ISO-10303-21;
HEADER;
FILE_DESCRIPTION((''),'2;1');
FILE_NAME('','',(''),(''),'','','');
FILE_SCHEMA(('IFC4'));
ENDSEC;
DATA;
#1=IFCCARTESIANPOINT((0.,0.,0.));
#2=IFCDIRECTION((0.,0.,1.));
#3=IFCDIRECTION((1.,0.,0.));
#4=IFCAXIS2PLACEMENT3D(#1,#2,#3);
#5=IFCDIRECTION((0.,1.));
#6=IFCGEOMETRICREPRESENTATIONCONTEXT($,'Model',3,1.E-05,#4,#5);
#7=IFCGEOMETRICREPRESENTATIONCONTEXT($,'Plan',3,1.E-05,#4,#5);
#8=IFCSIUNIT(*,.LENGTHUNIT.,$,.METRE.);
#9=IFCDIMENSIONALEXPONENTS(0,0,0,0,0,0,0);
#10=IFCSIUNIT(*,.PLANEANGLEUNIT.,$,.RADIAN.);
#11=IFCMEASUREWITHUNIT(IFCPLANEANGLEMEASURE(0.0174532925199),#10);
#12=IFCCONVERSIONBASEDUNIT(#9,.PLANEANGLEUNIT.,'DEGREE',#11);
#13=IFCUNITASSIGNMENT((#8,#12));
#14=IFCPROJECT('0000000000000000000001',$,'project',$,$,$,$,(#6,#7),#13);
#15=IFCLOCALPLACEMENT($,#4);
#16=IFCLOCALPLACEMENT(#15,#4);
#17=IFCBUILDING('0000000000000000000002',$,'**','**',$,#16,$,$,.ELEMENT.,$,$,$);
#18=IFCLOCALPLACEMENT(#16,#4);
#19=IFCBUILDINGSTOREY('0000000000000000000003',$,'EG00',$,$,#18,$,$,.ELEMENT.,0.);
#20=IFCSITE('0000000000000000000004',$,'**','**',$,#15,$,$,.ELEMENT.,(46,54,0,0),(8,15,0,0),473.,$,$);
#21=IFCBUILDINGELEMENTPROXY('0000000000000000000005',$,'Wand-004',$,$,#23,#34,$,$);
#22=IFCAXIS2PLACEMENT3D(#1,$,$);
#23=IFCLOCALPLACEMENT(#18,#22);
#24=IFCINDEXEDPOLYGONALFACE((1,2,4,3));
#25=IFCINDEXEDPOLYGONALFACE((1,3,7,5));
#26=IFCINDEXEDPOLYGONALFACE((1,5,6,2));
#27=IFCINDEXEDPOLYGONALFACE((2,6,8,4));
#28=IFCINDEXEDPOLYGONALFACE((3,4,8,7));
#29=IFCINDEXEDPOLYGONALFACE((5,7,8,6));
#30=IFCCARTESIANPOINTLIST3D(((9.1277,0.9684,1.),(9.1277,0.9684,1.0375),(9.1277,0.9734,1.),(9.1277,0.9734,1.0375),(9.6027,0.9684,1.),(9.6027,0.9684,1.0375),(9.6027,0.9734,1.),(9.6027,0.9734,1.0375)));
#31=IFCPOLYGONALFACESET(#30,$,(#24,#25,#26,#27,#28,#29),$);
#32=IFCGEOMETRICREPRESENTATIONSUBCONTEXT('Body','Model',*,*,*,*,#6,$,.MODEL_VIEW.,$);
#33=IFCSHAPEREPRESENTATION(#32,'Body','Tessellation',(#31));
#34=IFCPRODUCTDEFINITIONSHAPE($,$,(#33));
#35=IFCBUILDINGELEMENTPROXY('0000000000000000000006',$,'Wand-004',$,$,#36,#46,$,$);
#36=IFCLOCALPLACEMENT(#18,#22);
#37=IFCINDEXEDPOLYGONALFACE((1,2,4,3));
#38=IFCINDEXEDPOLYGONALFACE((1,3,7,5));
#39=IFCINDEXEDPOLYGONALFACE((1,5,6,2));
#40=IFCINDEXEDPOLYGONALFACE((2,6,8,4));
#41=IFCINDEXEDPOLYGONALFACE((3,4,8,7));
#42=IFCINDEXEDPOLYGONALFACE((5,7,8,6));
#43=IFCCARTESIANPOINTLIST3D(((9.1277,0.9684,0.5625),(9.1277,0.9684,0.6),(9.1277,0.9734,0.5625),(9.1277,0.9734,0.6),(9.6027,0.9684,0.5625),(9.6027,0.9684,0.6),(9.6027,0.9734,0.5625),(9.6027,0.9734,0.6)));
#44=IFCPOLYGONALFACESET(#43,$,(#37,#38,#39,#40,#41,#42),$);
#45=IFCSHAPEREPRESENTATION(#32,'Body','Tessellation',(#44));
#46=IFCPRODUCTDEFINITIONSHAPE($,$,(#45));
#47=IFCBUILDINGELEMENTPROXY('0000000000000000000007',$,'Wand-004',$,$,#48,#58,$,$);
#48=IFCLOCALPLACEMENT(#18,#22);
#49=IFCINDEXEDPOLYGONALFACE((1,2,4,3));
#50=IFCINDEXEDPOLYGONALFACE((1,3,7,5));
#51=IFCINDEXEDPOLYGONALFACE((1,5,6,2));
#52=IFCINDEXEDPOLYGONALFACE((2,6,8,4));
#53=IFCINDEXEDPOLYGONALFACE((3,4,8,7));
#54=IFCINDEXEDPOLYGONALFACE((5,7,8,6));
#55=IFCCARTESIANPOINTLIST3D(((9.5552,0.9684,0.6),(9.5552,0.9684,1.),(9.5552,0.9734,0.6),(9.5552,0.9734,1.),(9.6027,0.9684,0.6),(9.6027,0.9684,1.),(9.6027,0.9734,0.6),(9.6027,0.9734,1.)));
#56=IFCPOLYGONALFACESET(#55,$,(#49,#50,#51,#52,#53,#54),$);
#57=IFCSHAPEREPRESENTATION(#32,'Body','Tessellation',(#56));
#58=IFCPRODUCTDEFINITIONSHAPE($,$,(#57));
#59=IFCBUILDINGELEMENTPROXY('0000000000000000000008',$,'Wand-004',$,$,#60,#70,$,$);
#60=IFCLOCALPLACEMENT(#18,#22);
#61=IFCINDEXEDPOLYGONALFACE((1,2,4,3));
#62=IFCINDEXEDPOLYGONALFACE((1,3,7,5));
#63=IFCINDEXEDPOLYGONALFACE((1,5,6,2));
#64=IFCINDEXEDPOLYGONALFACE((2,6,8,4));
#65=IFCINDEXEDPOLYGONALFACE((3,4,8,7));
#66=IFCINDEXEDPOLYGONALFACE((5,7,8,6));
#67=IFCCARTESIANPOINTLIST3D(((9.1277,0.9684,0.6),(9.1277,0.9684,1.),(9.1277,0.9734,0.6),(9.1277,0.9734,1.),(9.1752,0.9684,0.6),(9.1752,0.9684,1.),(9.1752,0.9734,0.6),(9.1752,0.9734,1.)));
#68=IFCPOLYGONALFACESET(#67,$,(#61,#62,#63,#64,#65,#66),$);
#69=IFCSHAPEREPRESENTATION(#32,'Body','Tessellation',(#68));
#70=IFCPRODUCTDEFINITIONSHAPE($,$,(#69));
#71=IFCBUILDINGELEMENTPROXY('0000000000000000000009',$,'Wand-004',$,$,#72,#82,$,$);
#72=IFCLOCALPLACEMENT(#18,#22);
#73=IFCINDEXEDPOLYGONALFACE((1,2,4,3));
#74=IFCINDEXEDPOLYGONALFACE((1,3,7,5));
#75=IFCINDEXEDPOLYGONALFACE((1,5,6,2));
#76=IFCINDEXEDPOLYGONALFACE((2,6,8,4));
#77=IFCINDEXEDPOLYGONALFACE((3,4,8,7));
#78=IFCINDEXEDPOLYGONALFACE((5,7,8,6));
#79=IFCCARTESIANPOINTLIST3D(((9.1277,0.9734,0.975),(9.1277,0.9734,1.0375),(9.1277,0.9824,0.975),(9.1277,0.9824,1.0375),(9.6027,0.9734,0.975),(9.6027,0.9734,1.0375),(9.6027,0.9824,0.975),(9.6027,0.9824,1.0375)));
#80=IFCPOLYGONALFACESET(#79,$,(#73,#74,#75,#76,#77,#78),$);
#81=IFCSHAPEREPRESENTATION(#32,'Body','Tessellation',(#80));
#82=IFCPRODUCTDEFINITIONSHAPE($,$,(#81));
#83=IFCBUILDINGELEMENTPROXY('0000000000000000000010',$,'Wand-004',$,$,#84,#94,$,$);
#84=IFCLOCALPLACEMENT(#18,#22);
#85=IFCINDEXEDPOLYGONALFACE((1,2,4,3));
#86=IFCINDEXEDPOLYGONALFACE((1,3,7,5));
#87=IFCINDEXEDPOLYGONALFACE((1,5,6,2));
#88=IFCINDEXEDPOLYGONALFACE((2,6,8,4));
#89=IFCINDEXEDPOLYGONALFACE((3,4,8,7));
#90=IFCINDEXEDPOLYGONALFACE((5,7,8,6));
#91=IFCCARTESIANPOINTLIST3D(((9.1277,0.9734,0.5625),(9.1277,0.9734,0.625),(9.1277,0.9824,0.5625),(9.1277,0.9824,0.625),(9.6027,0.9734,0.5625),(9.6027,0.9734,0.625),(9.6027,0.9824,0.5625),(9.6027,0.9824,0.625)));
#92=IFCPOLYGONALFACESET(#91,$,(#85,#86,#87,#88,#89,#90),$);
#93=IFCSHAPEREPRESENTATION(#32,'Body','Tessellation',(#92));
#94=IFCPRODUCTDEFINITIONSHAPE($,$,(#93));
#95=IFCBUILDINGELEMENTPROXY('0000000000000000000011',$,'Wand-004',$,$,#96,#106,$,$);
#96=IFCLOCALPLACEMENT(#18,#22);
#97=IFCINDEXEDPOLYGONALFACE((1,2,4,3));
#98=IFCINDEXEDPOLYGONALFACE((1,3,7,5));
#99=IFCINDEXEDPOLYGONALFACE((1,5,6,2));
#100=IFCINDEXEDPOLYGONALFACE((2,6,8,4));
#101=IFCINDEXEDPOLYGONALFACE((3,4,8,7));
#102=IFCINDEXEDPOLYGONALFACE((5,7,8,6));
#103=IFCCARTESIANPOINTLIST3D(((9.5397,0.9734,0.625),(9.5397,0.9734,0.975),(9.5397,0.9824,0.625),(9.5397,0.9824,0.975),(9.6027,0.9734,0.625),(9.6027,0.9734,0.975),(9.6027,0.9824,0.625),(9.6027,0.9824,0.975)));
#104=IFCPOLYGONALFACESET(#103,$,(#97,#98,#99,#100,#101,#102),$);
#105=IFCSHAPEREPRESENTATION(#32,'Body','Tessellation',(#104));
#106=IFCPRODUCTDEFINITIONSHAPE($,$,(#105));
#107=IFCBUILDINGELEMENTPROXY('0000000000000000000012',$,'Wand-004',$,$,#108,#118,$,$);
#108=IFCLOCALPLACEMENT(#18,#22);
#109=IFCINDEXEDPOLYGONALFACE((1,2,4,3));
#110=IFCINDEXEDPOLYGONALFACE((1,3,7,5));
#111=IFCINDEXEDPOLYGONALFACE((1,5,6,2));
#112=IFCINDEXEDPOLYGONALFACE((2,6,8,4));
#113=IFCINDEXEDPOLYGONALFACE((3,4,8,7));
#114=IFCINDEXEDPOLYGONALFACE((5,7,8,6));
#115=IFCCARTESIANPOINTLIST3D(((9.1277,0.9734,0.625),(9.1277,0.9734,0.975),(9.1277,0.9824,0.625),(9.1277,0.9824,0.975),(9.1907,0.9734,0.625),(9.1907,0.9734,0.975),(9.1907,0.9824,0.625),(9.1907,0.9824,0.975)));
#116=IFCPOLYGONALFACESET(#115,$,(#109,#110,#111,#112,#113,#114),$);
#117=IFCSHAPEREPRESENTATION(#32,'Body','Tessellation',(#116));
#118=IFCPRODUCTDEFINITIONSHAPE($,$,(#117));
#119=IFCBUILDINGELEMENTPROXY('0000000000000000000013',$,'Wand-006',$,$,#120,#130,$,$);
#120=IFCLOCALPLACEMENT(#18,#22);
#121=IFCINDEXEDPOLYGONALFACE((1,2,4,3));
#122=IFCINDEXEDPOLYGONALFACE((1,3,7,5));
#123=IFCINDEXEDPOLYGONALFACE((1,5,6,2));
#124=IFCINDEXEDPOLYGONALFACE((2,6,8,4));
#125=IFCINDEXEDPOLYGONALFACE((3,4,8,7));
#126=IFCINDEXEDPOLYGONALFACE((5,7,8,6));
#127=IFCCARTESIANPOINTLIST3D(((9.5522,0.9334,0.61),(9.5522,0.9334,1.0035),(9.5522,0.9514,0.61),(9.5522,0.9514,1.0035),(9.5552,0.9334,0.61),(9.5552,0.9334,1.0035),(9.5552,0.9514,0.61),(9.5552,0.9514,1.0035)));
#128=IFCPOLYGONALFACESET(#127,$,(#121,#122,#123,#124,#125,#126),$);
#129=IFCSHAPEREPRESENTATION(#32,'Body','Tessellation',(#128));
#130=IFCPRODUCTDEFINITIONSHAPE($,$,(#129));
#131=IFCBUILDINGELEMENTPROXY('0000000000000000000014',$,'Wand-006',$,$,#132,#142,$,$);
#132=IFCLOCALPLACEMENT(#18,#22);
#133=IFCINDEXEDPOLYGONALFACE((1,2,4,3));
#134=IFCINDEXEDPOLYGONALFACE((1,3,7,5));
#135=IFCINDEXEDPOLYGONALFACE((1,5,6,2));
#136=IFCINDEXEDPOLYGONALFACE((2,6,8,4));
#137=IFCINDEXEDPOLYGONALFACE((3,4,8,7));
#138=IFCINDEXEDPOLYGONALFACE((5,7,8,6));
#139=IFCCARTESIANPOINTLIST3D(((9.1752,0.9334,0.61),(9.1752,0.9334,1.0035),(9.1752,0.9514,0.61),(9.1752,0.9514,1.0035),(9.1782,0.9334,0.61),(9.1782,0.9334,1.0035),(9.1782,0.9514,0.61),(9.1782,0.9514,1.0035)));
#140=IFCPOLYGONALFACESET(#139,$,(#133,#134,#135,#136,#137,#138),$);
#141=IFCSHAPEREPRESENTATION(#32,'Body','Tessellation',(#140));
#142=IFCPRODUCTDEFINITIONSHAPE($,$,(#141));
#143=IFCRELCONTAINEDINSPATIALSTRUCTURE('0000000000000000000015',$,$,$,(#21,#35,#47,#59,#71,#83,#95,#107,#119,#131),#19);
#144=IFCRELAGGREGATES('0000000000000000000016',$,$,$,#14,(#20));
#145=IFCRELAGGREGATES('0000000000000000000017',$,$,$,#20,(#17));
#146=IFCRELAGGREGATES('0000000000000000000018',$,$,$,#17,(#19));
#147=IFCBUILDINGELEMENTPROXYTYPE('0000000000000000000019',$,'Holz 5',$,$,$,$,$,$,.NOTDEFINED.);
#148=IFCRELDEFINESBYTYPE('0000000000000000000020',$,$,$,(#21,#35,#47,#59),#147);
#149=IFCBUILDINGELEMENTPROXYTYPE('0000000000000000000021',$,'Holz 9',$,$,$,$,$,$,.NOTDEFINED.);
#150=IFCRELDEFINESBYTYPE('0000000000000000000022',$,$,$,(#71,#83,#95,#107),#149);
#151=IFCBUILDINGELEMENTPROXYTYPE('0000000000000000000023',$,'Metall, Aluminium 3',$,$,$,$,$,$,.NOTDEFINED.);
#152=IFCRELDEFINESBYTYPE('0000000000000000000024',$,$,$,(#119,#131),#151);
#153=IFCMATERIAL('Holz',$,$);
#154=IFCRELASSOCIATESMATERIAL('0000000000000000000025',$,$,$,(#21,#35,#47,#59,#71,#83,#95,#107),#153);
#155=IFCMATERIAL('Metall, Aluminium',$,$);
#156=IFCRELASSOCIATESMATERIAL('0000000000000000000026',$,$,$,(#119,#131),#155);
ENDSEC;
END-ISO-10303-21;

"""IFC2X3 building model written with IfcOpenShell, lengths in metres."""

from ifc_helpers import new_model, entity, si_unit, converted_unit, direction, frame, origin_with_axes, place, context, subcontext, project, spatial, polyline, outline, extrude, material, type_object, element, save


model = new_model("IFC2X3")

# Units and contexts
model_context = context("Model", 3, precision=1e-05, world=origin_with_axes(), true_north=direction((0.0, 1.0)))
plan_context = context("Plan", 3, precision=1e-05, world=origin_with_axes(), true_north=direction((0.0, 1.0)))
body_context = subcontext(model_context, "Body", "Model", "MODEL_VIEW")
ifc_project = project(units=[si_unit("LENGTHUNIT", "METRE"), converted_unit("PLANEANGLEUNIT", "DEGREE", entity("IfcPlaneAngleMeasure", 0.0174532925199), si_unit("PLANEANGLEUNIT", "RADIAN"), dimensions=[0, 0, 0, 0, 0, 0, 0])], contexts=[model_context, plan_context])

# Site, building, storey
site_placement = place(None, origin_with_axes())
site = spatial("IfcSite", under=ifc_project, at=site_placement, Name="**", Description="**", CompositionType="ELEMENT", RefLatitude=(46, 54, 0, 0), RefLongitude=(8, 15, 0, 0), RefElevation=473.0)
building_placement = place(site_placement, origin_with_axes())
building = spatial("IfcBuilding", under=site, at=building_placement, Name="**", Description="**", CompositionType="ELEMENT")
storey_placement = place(building_placement, origin_with_axes())
storey = spatial("IfcBuildingStorey", under=building, at=storey_placement, Name="EG00", CompositionType="ELEMENT", Elevation=0.0)

# Building element proxies
ifc_material_1 = material(Name="Holz")
building_element_proxy_type_1 = type_object("IfcBuildingElementProxyType", Name="Holz 5", PredefinedType="NOTDEFINED")
for number, where, z_axis, x_axis, name in (
    (1, (9.6027, 0.9684, 1.0), (0.0, 0.0, 1.0), (-1.0, 0.0, 0.0), "Wand-004"),
    (2, (9.6027, 0.9684, 0.5625), (0.0, 0.0, 1.0), (-1.0, 0.0, 0.0), "Wand-004"),
):
    element("IfcBuildingElementProxy", number, at=place(storey_placement, frame(where, z_axis=z_axis, x_axis=x_axis)), inside=storey, type_object=building_element_proxy_type_1, material=ifc_material_1, Name=name, context=body_context, shape_type="SweptSolid", body=[
        extrude(outline(polyline([(0.0, -0.005), (0.475, -0.005), (0.475, 0.0), (0.0, 0.0), (0.0, -0.005)])), origin_with_axes(), (0.0, 0.0, 1.0), 0.0375),
    ])
for number, where, z_axis, x_axis, name in (
    (3, (9.5552, 0.9684, 0.6), (0.0, 0.0, 1.0), (1.0, 0.0, 0.0), "Wand-004"),
    (4, (9.1277, 0.9684, 0.6), (0.0, 0.0, 1.0), (1.0, 0.0, 0.0), "Wand-004"),
):
    element("IfcBuildingElementProxy", number, at=place(storey_placement, frame(where, z_axis=z_axis, x_axis=x_axis)), inside=storey, type_object=building_element_proxy_type_1, material=ifc_material_1, Name=name, context=body_context, shape_type="SweptSolid", body=[
        extrude(outline(polyline([(0.0, 0.0), (0.0475, 0.0), (0.0475, 0.005), (0.0, 0.005), (0.0, 0.0)])), origin_with_axes(), (0.0, 0.0, 1.0), 0.4),
    ])
building_element_proxy_type_2 = type_object("IfcBuildingElementProxyType", Name="Holz 9", PredefinedType="NOTDEFINED")
for number, where, z_axis, x_axis, name in (
    (5, (9.6027, 0.9734, 0.975), (0.0, 0.0, 1.0), (-1.0, 0.0, 0.0), "Wand-004"),
    (6, (9.6027, 0.9734, 0.5625), (0.0, 0.0, 1.0), (-1.0, 0.0, 0.0), "Wand-004"),
):
    element("IfcBuildingElementProxy", number, at=place(storey_placement, frame(where, z_axis=z_axis, x_axis=x_axis)), inside=storey, type_object=building_element_proxy_type_2, material=ifc_material_1, Name=name, context=body_context, shape_type="SweptSolid", body=[
        extrude(outline(polyline([(0.0, -0.009), (0.475, -0.009), (0.475, 0.0), (0.0, 0.0), (0.0, -0.009)])), origin_with_axes(), (0.0, 0.0, 1.0), 0.0625),
    ])
for number, where, z_axis, x_axis, name in (
    (7, (9.5397, 0.9734, 0.625), (0.0, 0.0, 1.0), (1.0, 0.0, 0.0), "Wand-004"),
    (8, (9.1277, 0.9734, 0.625), (0.0, 0.0, 1.0), (1.0, 0.0, 0.0), "Wand-004"),
):
    element("IfcBuildingElementProxy", number, at=place(storey_placement, frame(where, z_axis=z_axis, x_axis=x_axis)), inside=storey, type_object=building_element_proxy_type_2, material=ifc_material_1, Name=name, context=body_context, shape_type="SweptSolid", body=[
        extrude(outline(polyline([(0.0, 0.0), (0.063, 0.0), (0.063, 0.009), (0.0, 0.009), (0.0, 0.0)])), origin_with_axes(), (0.0, 0.0, 1.0), 0.35),
    ])
ifc_material_2 = material(Name="Metall, Aluminium")
building_element_proxy_type_3 = type_object("IfcBuildingElementProxyType", Name="Metall, Aluminium 3", PredefinedType="NOTDEFINED")
proxy_1_placement = place(storey_placement, frame((9.5552, 0.9514, 0.61), z_axis=(0.0, 0.0, 1.0), x_axis=(0.0, -1.0, 0.0)))
element("IfcBuildingElementProxy", 9, at=proxy_1_placement, inside=storey, type_object=building_element_proxy_type_3, material=ifc_material_2, Name="Wand-006", context=body_context, shape_type="SweptSolid", body=[
    extrude(outline(polyline([(0.0, -0.003), (0.018, -0.003), (0.018, 0.0), (0.0, 0.0), (0.0, -0.003)])), origin_with_axes(), (0.0, 0.0, 1.0), 0.3935),
])
proxy_2_placement = place(storey_placement, frame((9.1752, 0.9514, 0.61), z_axis=(0.0, 0.0, 1.0), x_axis=(0.0, -1.0, 0.0)))
element("IfcBuildingElementProxy", 10, at=proxy_2_placement, inside=storey, type_object=building_element_proxy_type_3, material=ifc_material_2, Name="Wand-006", context=body_context, shape_type="SweptSolid", body=[
    extrude(outline(polyline([(0.0, 0.0), (0.018, 0.0), (0.018, 0.003), (0.0, 0.003), (0.0, 0.0)])), origin_with_axes(), (0.0, 0.0, 1.0), 0.3935),
])

save(model, "model.ifc")
